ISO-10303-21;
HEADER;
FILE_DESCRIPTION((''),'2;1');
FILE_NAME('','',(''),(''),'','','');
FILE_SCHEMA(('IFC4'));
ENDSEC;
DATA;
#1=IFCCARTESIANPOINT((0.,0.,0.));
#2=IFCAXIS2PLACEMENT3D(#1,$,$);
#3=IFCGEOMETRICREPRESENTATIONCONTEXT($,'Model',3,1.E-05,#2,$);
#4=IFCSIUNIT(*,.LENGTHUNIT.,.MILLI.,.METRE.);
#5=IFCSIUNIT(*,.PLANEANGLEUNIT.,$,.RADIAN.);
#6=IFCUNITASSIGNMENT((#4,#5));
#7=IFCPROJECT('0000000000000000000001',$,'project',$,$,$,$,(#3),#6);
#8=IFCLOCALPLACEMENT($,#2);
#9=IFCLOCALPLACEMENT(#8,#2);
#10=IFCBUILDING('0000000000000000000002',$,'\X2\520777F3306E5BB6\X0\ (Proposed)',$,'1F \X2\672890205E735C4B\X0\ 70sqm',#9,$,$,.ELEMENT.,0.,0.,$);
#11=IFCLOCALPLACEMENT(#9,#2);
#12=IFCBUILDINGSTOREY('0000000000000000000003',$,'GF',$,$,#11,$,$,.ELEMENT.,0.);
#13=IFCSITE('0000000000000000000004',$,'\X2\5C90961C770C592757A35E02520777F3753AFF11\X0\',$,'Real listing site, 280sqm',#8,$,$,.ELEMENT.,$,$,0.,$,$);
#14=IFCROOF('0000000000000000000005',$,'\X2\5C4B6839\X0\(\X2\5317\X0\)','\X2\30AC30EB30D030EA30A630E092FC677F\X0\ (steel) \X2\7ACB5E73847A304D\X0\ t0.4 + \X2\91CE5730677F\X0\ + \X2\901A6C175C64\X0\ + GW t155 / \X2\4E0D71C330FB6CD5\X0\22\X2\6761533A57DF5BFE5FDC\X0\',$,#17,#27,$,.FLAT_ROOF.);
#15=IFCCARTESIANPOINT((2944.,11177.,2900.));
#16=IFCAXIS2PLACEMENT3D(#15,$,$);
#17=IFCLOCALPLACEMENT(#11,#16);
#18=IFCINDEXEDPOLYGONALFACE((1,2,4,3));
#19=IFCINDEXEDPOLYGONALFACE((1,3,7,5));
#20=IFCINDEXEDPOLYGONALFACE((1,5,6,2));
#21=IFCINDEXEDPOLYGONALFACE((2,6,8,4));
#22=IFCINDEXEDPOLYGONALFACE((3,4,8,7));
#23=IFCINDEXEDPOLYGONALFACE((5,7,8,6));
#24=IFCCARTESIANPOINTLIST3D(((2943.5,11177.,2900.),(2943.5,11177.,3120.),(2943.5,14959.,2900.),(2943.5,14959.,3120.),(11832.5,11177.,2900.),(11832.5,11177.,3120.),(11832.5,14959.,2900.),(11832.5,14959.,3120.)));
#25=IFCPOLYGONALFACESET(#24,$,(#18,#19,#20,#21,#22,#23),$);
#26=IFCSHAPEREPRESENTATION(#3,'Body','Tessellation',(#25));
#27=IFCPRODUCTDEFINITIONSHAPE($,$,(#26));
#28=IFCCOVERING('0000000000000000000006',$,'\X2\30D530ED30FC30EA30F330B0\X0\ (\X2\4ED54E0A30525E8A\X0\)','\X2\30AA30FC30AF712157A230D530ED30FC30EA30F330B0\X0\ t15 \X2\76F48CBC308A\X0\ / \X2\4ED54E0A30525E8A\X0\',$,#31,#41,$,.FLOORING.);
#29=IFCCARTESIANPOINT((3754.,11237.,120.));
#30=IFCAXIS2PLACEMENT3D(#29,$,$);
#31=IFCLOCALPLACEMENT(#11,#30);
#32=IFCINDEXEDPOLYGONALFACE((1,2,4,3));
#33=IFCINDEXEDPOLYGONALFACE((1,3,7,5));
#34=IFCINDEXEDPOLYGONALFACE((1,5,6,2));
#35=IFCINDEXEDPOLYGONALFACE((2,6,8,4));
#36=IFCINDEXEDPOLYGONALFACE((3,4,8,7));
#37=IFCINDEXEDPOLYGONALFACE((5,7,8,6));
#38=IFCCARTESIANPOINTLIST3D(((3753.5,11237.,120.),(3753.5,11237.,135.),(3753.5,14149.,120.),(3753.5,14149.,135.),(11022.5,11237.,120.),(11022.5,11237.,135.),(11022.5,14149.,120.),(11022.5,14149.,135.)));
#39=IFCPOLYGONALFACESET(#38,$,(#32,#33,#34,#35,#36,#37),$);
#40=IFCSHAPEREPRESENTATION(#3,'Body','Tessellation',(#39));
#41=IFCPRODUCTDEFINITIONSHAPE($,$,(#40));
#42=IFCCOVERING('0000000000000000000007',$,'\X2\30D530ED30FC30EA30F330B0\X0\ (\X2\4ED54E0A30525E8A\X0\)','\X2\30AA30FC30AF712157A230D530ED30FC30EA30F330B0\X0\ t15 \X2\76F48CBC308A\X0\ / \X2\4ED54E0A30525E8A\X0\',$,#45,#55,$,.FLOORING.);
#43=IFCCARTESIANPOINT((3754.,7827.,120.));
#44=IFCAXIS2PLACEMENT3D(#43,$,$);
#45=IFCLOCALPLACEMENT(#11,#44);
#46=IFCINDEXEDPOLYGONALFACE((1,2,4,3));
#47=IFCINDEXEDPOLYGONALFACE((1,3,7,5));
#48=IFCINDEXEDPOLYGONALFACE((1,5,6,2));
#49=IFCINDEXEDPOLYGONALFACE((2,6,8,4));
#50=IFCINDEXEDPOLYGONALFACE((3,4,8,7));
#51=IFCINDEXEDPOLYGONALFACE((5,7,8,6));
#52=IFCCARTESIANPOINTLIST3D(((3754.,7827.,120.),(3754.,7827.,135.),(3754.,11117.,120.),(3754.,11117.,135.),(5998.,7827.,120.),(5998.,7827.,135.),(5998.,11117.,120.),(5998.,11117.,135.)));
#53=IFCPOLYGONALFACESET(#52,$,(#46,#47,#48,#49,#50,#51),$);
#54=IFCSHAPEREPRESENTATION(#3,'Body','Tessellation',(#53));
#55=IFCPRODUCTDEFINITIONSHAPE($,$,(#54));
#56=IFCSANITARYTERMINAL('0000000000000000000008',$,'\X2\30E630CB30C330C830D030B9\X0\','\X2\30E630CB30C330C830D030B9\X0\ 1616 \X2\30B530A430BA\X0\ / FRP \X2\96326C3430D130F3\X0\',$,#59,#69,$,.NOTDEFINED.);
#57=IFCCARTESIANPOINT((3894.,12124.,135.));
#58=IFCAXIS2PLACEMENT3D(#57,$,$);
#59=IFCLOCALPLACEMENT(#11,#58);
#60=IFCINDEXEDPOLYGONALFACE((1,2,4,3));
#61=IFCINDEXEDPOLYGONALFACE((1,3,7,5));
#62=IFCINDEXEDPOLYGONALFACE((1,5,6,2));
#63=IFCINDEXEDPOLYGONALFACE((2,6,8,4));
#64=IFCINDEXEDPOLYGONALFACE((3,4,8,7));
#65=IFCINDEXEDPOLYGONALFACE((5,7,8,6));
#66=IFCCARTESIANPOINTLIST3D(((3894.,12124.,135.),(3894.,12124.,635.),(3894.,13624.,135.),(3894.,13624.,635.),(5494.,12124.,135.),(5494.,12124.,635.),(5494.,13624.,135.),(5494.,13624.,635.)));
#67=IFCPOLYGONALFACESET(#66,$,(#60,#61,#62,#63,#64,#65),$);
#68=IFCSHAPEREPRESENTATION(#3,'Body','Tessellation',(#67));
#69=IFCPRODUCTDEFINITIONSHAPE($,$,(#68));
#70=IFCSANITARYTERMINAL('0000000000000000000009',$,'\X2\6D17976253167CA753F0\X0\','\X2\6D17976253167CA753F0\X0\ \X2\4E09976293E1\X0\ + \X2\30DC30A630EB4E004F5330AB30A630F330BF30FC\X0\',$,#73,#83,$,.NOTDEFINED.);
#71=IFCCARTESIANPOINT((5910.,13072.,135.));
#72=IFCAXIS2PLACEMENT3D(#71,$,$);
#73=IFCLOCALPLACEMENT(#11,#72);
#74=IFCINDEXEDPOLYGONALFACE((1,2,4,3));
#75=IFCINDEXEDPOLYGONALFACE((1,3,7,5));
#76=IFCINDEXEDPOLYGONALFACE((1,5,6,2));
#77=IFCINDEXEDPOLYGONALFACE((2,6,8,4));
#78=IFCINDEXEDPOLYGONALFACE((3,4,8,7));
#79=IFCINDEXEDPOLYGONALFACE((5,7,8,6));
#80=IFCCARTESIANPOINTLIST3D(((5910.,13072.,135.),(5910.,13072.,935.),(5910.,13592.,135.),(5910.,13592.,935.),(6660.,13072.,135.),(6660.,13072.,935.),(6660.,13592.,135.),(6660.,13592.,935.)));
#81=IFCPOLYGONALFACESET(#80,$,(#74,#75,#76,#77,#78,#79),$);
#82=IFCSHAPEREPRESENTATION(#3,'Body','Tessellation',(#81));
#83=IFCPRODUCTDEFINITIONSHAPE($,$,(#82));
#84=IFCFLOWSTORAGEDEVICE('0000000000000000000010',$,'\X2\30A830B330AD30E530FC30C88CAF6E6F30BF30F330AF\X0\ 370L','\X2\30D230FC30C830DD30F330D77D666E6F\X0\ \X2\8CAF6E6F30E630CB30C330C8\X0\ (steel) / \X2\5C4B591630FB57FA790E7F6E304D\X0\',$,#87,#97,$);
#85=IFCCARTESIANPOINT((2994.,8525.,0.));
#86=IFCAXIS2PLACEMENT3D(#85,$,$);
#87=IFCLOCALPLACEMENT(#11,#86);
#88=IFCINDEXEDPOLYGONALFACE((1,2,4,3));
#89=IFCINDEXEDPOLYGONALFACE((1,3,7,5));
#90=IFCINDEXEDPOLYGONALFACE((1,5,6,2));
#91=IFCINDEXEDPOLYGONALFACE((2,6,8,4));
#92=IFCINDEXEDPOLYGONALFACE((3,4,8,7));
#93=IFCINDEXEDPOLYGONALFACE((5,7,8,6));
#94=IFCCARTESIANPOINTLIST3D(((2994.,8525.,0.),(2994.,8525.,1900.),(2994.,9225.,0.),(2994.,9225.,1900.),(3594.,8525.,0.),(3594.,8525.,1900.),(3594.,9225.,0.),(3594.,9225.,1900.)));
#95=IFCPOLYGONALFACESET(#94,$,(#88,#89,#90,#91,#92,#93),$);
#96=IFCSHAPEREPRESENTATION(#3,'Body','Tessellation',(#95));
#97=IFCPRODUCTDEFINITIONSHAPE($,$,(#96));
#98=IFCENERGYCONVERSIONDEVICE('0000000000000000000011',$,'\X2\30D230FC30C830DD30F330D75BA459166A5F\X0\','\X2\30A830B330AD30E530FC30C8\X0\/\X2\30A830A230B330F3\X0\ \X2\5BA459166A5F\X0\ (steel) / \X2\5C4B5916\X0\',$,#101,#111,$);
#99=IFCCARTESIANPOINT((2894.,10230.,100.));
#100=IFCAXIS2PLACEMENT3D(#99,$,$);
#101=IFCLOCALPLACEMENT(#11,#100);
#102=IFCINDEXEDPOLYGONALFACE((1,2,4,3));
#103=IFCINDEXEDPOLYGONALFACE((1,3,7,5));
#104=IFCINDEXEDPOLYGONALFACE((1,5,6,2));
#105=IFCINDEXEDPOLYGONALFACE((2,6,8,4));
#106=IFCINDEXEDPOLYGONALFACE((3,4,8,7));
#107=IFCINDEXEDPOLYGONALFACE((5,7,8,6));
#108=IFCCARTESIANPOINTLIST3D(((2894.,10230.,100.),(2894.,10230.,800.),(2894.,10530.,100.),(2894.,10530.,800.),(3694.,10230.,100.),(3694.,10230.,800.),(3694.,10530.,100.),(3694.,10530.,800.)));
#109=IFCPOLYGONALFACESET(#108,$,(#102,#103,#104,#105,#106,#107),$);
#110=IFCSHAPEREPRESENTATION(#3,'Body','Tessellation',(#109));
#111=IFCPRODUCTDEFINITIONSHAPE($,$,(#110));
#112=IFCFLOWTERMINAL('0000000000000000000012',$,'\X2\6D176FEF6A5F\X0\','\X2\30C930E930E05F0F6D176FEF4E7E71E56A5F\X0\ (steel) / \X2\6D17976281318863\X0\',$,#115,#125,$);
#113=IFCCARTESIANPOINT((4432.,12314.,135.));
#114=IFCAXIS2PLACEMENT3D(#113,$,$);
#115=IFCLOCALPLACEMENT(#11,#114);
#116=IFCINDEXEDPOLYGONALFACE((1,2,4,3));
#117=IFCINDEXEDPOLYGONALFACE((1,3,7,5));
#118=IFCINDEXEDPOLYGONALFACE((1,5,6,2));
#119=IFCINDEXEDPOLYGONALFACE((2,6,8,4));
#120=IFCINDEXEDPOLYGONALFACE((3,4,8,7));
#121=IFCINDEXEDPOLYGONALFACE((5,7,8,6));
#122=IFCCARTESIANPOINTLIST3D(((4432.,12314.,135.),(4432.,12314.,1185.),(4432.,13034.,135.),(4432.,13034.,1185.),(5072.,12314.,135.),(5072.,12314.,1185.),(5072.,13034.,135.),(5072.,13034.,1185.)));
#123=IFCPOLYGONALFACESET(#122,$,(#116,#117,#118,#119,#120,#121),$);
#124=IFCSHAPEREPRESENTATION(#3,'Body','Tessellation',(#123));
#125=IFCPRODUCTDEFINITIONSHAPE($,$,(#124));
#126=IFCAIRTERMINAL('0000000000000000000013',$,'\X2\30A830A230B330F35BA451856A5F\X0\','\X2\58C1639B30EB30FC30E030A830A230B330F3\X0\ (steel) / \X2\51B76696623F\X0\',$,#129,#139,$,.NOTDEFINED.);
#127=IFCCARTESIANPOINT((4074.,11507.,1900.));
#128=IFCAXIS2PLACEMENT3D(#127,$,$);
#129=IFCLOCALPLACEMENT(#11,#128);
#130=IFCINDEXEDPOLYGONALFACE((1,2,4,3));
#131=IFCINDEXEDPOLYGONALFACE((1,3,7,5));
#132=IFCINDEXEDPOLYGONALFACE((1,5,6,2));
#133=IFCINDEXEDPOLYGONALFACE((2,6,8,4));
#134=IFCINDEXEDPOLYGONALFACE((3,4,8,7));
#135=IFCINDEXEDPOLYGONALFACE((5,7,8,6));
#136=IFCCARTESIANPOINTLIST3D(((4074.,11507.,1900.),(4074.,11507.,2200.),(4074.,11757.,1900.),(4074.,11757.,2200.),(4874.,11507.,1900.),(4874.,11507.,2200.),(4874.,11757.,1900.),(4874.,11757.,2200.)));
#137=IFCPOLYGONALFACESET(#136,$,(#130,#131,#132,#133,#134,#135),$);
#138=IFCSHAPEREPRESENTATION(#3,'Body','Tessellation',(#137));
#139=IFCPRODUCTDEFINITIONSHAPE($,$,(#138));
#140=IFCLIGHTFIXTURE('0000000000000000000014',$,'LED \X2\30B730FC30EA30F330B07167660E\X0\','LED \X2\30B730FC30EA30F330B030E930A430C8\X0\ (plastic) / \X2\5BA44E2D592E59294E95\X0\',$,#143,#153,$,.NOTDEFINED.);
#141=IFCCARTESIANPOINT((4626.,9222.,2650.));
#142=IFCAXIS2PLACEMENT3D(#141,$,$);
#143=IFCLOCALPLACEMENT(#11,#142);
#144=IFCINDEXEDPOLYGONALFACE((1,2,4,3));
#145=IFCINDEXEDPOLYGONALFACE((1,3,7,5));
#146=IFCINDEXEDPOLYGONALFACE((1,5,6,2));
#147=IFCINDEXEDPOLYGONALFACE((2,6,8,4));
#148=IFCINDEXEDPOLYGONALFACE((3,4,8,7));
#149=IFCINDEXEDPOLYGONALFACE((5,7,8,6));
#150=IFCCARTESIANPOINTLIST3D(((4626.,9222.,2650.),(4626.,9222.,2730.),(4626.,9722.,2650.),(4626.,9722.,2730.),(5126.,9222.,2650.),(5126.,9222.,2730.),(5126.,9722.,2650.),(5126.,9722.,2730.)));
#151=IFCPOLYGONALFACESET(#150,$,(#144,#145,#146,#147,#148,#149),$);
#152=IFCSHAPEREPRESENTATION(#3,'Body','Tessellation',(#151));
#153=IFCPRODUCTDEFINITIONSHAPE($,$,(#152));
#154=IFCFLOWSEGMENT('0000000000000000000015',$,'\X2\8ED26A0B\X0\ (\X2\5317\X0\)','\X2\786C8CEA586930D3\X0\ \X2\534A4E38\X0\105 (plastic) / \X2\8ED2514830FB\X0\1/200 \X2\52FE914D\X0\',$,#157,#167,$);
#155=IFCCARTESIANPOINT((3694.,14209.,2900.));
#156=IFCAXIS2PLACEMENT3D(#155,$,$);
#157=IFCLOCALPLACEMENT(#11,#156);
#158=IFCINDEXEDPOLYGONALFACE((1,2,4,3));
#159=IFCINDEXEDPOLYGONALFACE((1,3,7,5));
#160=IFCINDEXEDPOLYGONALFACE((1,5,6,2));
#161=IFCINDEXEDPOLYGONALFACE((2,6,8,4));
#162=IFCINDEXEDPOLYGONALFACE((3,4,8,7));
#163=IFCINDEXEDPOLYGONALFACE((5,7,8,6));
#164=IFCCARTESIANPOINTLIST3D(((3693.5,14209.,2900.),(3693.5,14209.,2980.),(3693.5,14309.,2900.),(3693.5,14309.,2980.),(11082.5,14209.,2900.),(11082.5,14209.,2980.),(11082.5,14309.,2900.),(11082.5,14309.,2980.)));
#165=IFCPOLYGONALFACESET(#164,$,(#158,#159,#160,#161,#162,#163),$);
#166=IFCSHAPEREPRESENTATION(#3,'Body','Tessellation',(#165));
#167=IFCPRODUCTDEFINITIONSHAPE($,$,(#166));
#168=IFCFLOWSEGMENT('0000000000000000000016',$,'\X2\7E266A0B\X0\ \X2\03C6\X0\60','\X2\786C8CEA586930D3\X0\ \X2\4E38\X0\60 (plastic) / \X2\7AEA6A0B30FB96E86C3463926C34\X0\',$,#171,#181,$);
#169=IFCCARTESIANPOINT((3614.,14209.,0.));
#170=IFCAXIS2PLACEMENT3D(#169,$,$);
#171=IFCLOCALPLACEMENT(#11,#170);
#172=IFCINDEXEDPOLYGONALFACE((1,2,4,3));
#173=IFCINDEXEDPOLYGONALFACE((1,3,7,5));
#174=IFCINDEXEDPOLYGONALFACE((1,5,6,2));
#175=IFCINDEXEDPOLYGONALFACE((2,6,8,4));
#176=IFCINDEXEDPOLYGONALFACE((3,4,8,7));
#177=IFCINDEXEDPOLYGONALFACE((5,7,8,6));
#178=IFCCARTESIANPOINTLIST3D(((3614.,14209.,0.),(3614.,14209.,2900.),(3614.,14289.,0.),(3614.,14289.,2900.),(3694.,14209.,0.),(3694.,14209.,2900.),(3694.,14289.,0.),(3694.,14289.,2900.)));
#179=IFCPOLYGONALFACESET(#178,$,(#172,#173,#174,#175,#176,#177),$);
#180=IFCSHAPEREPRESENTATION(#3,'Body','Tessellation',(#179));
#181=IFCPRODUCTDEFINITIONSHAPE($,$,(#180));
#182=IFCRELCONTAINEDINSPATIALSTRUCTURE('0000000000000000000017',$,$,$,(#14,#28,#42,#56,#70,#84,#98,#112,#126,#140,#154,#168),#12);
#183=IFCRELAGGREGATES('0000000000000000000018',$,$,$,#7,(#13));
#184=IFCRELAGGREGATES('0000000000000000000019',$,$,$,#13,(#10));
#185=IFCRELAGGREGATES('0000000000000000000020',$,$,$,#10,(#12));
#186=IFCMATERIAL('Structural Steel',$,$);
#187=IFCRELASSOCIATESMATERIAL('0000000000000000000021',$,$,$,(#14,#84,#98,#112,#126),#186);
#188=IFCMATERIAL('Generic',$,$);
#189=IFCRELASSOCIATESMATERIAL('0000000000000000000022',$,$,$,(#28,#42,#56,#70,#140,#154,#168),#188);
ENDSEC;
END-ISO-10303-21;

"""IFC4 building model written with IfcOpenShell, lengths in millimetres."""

from ifc_helpers import new_model, si_unit, frame, frame_2d, origin, place, context, project, spatial, rectangle, extrude, material, element, save


model = new_model("IFC4")

# Units and contexts
model_context = context("Model", 3, precision=1e-05, world=origin())
ifc_project = project(units=[si_unit("LENGTHUNIT", "METRE", prefix="MILLI"), si_unit("PLANEANGLEUNIT", "RADIAN")], contexts=[model_context])

# Site, building, storey
site_placement = place(None, origin())
site = spatial("IfcSite", under=ifc_project, at=site_placement, Name="岐阜県大垣市切石町１", ObjectType="Real listing site, 280sqm", CompositionType="ELEMENT", RefElevation=0.0)
building_placement = place(site_placement, origin())
building = spatial("IfcBuilding", under=site, at=building_placement, Name="切石の家 (Proposed)", ObjectType="1F 木造平屋 70sqm", CompositionType="ELEMENT", ElevationOfRefHeight=0.0, ElevationOfTerrain=0.0)
storey_placement = place(building_placement, origin())
storey = spatial("IfcBuildingStorey", under=building, at=storey_placement, Name="GF", CompositionType="ELEMENT", Elevation=0.0)

# Roof
ifc_material_1 = material(Name="Structural Steel")
roof_placement = place(storey_placement, frame((2944.0, 11177.0, 2900.0)))
element("IfcRoof", 1, at=roof_placement, inside=storey, material=ifc_material_1, Name="屋根(北)", Description="ガルバリウム鋼板 (steel) 立平葺き t0.4 + 野地板 + 通気層 + GW t155 / 不燃・法22条区域対応", PredefinedType="FLAT_ROOF", context=model_context, shape_type="SweptSolid", body=[
    extrude(rectangle(XDim=8889.0, YDim=3782.0, at=frame_2d((4444.0, 1891.0))), frame((2944.0, 11177.0, 2900.0)), (0.0, 0.0, 1.0), 220.0),
])

# Coverings
ifc_material_2 = material(Name="Generic")
covering_1_placement = place(storey_placement, frame((3754.0, 11237.0, 120.0)))
element("IfcCovering", 2, at=covering_1_placement, inside=storey, material=ifc_material_2, Name="フローリング (仕上げ床)", Description="オーク無垢フローリング t15 直貼り / 仕上げ床", PredefinedType="FLOORING", context=model_context, shape_type="SweptSolid", body=[
    extrude(rectangle(XDim=7269.0, YDim=2912.0, at=frame_2d((3634.0, 1456.0))), frame((3754.0, 11237.0, 120.0)), (0.0, 0.0, 1.0), 15.0),
])
covering_2_placement = place(storey_placement, frame((3754.0, 7827.0, 120.0)))
element("IfcCovering", 3, at=covering_2_placement, inside=storey, material=ifc_material_2, Name="フローリング (仕上げ床)", Description="オーク無垢フローリング t15 直貼り / 仕上げ床", PredefinedType="FLOORING", context=model_context, shape_type="SweptSolid", body=[
    extrude(rectangle(XDim=2244.0, YDim=3290.0, at=frame_2d((1122.0, 1645.0))), frame((3754.0, 7827.0, 120.0)), (0.0, 0.0, 1.0), 15.0),
])

# Sanitary terminals
sanitary_terminal_1_placement = place(storey_placement, frame((3894.0, 12124.0, 135.0)))
element("IfcSanitaryTerminal", 4, at=sanitary_terminal_1_placement, inside=storey, material=ifc_material_2, Name="ユニットバス", Description="ユニットバス 1616 サイズ / FRP 防水パン", PredefinedType="NOTDEFINED", context=model_context, shape_type="SweptSolid", body=[
    extrude(rectangle(XDim=1600.0, YDim=1500.0, at=frame_2d((800.0, 750.0))), frame((3894.0, 12124.0, 135.0)), (0.0, 0.0, 1.0), 500.0),
])
sanitary_terminal_2_placement = place(storey_placement, frame((5910.0, 13072.0, 135.0)))
element("IfcSanitaryTerminal", 5, at=sanitary_terminal_2_placement, inside=storey, material=ifc_material_2, Name="洗面化粧台", Description="洗面化粧台 三面鏡 + ボウル一体カウンター", PredefinedType="NOTDEFINED", context=model_context, shape_type="SweptSolid", body=[
    extrude(rectangle(XDim=750.0, YDim=520.0, at=frame_2d((375.0, 260.0))), frame((5910.0, 13072.0, 135.0)), (0.0, 0.0, 1.0), 800.0),
])

# Flow storage device
flow_storage_device_placement = place(storey_placement, frame((2994.0, 8525.0, 0.0)))
element("IfcFlowStorageDevice", 6, at=flow_storage_device_placement, inside=storey, material=ifc_material_1, Name="エコキュート貯湯タンク 370L", Description="ヒートポンプ給湯 貯湯ユニット (steel) / 屋外・基礎置き", context=model_context, shape_type="SweptSolid", body=[
    extrude(rectangle(XDim=600.0, YDim=700.0, at=frame_2d((300.0, 350.0))), frame((2994.0, 8525.0, 0.0)), (0.0, 0.0, 1.0), 1900.0),
])

# Energy conversion device
energy_conversion_device_placement = place(storey_placement, frame((2894.0, 10230.0, 100.0)))
element("IfcEnergyConversionDevice", 7, at=energy_conversion_device_placement, inside=storey, material=ifc_material_1, Name="ヒートポンプ室外機", Description="エコキュート/エアコン 室外機 (steel) / 屋外", context=model_context, shape_type="SweptSolid", body=[
    extrude(rectangle(XDim=800.0, YDim=300.0, at=frame_2d((400.0, 150.0))), frame((2894.0, 10230.0, 100.0)), (0.0, 0.0, 1.0), 700.0),
])

# Flow terminal
flow_terminal_placement = place(storey_placement, frame((4432.0, 12314.0, 135.0)))
element("IfcFlowTerminal", 8, at=flow_terminal_placement, inside=storey, material=ifc_material_1, Name="洗濯機", Description="ドラム式洗濯乾燥機 (steel) / 洗面脱衣", context=model_context, shape_type="SweptSolid", body=[
    extrude(rectangle(XDim=640.0, YDim=720.0, at=frame_2d((320.0, 360.0))), frame((4432.0, 12314.0, 135.0)), (0.0, 0.0, 1.0), 1050.0),
])

# Air terminal
air_terminal_placement = place(storey_placement, frame((4074.0, 11507.0, 1900.0)))
element("IfcAirTerminal", 9, at=air_terminal_placement, inside=storey, material=ifc_material_1, Name="エアコン室内機", Description="壁掛ルームエアコン (steel) / 冷暖房", PredefinedType="NOTDEFINED", context=model_context, shape_type="SweptSolid", body=[
    extrude(rectangle(XDim=800.0, YDim=250.0, at=frame_2d((400.0, 125.0))), frame((4074.0, 11507.0, 1900.0)), (0.0, 0.0, 1.0), 300.0),
])

# Light fixture
light_fixture_placement = place(storey_placement, frame((4626.0, 9222.0, 2650.0)))
element("IfcLightFixture", 10, at=light_fixture_placement, inside=storey, material=ifc_material_2, Name="LED シーリング照明", Description="LED シーリングライト (plastic) / 室中央天井", PredefinedType="NOTDEFINED", context=model_context, shape_type="SweptSolid", body=[
    extrude(rectangle(XDim=500.0, YDim=500.0, at=frame_2d((250.0, 250.0))), frame((4626.0, 9222.0, 2650.0)), (0.0, 0.0, 1.0), 80.0),
])

# Flow segments
flow_segment_1_placement = place(storey_placement, frame((3694.0, 14209.0, 2900.0)))
element("IfcFlowSegment", 11, at=flow_segment_1_placement, inside=storey, material=ifc_material_2, Name="軒樋 (北)", Description="硬質塩ビ 半丸105 (plastic) / 軒先・1/200 勾配", context=model_context, shape_type="SweptSolid", body=[
    extrude(rectangle(XDim=7389.0, YDim=100.0, at=frame_2d((3694.0, 50.0))), frame((3694.0, 14209.0, 2900.0)), (0.0, 0.0, 1.0), 80.0),
])
flow_segment_2_placement = place(storey_placement, frame((3614.0, 14209.0, 0.0)))
element("IfcFlowSegment", 12, at=flow_segment_2_placement, inside=storey, material=ifc_material_2, Name="縦樋 φ60", Description="硬質塩ビ 丸60 (plastic) / 竪樋・雨水排水", context=model_context, shape_type="SweptSolid", body=[
    extrude(rectangle(XDim=80.0, YDim=80.0, at=frame_2d((40.0, 40.0))), frame((3614.0, 14209.0, 0.0)), (0.0, 0.0, 1.0), 2900.0),
])

save(model, "model.ifc")
